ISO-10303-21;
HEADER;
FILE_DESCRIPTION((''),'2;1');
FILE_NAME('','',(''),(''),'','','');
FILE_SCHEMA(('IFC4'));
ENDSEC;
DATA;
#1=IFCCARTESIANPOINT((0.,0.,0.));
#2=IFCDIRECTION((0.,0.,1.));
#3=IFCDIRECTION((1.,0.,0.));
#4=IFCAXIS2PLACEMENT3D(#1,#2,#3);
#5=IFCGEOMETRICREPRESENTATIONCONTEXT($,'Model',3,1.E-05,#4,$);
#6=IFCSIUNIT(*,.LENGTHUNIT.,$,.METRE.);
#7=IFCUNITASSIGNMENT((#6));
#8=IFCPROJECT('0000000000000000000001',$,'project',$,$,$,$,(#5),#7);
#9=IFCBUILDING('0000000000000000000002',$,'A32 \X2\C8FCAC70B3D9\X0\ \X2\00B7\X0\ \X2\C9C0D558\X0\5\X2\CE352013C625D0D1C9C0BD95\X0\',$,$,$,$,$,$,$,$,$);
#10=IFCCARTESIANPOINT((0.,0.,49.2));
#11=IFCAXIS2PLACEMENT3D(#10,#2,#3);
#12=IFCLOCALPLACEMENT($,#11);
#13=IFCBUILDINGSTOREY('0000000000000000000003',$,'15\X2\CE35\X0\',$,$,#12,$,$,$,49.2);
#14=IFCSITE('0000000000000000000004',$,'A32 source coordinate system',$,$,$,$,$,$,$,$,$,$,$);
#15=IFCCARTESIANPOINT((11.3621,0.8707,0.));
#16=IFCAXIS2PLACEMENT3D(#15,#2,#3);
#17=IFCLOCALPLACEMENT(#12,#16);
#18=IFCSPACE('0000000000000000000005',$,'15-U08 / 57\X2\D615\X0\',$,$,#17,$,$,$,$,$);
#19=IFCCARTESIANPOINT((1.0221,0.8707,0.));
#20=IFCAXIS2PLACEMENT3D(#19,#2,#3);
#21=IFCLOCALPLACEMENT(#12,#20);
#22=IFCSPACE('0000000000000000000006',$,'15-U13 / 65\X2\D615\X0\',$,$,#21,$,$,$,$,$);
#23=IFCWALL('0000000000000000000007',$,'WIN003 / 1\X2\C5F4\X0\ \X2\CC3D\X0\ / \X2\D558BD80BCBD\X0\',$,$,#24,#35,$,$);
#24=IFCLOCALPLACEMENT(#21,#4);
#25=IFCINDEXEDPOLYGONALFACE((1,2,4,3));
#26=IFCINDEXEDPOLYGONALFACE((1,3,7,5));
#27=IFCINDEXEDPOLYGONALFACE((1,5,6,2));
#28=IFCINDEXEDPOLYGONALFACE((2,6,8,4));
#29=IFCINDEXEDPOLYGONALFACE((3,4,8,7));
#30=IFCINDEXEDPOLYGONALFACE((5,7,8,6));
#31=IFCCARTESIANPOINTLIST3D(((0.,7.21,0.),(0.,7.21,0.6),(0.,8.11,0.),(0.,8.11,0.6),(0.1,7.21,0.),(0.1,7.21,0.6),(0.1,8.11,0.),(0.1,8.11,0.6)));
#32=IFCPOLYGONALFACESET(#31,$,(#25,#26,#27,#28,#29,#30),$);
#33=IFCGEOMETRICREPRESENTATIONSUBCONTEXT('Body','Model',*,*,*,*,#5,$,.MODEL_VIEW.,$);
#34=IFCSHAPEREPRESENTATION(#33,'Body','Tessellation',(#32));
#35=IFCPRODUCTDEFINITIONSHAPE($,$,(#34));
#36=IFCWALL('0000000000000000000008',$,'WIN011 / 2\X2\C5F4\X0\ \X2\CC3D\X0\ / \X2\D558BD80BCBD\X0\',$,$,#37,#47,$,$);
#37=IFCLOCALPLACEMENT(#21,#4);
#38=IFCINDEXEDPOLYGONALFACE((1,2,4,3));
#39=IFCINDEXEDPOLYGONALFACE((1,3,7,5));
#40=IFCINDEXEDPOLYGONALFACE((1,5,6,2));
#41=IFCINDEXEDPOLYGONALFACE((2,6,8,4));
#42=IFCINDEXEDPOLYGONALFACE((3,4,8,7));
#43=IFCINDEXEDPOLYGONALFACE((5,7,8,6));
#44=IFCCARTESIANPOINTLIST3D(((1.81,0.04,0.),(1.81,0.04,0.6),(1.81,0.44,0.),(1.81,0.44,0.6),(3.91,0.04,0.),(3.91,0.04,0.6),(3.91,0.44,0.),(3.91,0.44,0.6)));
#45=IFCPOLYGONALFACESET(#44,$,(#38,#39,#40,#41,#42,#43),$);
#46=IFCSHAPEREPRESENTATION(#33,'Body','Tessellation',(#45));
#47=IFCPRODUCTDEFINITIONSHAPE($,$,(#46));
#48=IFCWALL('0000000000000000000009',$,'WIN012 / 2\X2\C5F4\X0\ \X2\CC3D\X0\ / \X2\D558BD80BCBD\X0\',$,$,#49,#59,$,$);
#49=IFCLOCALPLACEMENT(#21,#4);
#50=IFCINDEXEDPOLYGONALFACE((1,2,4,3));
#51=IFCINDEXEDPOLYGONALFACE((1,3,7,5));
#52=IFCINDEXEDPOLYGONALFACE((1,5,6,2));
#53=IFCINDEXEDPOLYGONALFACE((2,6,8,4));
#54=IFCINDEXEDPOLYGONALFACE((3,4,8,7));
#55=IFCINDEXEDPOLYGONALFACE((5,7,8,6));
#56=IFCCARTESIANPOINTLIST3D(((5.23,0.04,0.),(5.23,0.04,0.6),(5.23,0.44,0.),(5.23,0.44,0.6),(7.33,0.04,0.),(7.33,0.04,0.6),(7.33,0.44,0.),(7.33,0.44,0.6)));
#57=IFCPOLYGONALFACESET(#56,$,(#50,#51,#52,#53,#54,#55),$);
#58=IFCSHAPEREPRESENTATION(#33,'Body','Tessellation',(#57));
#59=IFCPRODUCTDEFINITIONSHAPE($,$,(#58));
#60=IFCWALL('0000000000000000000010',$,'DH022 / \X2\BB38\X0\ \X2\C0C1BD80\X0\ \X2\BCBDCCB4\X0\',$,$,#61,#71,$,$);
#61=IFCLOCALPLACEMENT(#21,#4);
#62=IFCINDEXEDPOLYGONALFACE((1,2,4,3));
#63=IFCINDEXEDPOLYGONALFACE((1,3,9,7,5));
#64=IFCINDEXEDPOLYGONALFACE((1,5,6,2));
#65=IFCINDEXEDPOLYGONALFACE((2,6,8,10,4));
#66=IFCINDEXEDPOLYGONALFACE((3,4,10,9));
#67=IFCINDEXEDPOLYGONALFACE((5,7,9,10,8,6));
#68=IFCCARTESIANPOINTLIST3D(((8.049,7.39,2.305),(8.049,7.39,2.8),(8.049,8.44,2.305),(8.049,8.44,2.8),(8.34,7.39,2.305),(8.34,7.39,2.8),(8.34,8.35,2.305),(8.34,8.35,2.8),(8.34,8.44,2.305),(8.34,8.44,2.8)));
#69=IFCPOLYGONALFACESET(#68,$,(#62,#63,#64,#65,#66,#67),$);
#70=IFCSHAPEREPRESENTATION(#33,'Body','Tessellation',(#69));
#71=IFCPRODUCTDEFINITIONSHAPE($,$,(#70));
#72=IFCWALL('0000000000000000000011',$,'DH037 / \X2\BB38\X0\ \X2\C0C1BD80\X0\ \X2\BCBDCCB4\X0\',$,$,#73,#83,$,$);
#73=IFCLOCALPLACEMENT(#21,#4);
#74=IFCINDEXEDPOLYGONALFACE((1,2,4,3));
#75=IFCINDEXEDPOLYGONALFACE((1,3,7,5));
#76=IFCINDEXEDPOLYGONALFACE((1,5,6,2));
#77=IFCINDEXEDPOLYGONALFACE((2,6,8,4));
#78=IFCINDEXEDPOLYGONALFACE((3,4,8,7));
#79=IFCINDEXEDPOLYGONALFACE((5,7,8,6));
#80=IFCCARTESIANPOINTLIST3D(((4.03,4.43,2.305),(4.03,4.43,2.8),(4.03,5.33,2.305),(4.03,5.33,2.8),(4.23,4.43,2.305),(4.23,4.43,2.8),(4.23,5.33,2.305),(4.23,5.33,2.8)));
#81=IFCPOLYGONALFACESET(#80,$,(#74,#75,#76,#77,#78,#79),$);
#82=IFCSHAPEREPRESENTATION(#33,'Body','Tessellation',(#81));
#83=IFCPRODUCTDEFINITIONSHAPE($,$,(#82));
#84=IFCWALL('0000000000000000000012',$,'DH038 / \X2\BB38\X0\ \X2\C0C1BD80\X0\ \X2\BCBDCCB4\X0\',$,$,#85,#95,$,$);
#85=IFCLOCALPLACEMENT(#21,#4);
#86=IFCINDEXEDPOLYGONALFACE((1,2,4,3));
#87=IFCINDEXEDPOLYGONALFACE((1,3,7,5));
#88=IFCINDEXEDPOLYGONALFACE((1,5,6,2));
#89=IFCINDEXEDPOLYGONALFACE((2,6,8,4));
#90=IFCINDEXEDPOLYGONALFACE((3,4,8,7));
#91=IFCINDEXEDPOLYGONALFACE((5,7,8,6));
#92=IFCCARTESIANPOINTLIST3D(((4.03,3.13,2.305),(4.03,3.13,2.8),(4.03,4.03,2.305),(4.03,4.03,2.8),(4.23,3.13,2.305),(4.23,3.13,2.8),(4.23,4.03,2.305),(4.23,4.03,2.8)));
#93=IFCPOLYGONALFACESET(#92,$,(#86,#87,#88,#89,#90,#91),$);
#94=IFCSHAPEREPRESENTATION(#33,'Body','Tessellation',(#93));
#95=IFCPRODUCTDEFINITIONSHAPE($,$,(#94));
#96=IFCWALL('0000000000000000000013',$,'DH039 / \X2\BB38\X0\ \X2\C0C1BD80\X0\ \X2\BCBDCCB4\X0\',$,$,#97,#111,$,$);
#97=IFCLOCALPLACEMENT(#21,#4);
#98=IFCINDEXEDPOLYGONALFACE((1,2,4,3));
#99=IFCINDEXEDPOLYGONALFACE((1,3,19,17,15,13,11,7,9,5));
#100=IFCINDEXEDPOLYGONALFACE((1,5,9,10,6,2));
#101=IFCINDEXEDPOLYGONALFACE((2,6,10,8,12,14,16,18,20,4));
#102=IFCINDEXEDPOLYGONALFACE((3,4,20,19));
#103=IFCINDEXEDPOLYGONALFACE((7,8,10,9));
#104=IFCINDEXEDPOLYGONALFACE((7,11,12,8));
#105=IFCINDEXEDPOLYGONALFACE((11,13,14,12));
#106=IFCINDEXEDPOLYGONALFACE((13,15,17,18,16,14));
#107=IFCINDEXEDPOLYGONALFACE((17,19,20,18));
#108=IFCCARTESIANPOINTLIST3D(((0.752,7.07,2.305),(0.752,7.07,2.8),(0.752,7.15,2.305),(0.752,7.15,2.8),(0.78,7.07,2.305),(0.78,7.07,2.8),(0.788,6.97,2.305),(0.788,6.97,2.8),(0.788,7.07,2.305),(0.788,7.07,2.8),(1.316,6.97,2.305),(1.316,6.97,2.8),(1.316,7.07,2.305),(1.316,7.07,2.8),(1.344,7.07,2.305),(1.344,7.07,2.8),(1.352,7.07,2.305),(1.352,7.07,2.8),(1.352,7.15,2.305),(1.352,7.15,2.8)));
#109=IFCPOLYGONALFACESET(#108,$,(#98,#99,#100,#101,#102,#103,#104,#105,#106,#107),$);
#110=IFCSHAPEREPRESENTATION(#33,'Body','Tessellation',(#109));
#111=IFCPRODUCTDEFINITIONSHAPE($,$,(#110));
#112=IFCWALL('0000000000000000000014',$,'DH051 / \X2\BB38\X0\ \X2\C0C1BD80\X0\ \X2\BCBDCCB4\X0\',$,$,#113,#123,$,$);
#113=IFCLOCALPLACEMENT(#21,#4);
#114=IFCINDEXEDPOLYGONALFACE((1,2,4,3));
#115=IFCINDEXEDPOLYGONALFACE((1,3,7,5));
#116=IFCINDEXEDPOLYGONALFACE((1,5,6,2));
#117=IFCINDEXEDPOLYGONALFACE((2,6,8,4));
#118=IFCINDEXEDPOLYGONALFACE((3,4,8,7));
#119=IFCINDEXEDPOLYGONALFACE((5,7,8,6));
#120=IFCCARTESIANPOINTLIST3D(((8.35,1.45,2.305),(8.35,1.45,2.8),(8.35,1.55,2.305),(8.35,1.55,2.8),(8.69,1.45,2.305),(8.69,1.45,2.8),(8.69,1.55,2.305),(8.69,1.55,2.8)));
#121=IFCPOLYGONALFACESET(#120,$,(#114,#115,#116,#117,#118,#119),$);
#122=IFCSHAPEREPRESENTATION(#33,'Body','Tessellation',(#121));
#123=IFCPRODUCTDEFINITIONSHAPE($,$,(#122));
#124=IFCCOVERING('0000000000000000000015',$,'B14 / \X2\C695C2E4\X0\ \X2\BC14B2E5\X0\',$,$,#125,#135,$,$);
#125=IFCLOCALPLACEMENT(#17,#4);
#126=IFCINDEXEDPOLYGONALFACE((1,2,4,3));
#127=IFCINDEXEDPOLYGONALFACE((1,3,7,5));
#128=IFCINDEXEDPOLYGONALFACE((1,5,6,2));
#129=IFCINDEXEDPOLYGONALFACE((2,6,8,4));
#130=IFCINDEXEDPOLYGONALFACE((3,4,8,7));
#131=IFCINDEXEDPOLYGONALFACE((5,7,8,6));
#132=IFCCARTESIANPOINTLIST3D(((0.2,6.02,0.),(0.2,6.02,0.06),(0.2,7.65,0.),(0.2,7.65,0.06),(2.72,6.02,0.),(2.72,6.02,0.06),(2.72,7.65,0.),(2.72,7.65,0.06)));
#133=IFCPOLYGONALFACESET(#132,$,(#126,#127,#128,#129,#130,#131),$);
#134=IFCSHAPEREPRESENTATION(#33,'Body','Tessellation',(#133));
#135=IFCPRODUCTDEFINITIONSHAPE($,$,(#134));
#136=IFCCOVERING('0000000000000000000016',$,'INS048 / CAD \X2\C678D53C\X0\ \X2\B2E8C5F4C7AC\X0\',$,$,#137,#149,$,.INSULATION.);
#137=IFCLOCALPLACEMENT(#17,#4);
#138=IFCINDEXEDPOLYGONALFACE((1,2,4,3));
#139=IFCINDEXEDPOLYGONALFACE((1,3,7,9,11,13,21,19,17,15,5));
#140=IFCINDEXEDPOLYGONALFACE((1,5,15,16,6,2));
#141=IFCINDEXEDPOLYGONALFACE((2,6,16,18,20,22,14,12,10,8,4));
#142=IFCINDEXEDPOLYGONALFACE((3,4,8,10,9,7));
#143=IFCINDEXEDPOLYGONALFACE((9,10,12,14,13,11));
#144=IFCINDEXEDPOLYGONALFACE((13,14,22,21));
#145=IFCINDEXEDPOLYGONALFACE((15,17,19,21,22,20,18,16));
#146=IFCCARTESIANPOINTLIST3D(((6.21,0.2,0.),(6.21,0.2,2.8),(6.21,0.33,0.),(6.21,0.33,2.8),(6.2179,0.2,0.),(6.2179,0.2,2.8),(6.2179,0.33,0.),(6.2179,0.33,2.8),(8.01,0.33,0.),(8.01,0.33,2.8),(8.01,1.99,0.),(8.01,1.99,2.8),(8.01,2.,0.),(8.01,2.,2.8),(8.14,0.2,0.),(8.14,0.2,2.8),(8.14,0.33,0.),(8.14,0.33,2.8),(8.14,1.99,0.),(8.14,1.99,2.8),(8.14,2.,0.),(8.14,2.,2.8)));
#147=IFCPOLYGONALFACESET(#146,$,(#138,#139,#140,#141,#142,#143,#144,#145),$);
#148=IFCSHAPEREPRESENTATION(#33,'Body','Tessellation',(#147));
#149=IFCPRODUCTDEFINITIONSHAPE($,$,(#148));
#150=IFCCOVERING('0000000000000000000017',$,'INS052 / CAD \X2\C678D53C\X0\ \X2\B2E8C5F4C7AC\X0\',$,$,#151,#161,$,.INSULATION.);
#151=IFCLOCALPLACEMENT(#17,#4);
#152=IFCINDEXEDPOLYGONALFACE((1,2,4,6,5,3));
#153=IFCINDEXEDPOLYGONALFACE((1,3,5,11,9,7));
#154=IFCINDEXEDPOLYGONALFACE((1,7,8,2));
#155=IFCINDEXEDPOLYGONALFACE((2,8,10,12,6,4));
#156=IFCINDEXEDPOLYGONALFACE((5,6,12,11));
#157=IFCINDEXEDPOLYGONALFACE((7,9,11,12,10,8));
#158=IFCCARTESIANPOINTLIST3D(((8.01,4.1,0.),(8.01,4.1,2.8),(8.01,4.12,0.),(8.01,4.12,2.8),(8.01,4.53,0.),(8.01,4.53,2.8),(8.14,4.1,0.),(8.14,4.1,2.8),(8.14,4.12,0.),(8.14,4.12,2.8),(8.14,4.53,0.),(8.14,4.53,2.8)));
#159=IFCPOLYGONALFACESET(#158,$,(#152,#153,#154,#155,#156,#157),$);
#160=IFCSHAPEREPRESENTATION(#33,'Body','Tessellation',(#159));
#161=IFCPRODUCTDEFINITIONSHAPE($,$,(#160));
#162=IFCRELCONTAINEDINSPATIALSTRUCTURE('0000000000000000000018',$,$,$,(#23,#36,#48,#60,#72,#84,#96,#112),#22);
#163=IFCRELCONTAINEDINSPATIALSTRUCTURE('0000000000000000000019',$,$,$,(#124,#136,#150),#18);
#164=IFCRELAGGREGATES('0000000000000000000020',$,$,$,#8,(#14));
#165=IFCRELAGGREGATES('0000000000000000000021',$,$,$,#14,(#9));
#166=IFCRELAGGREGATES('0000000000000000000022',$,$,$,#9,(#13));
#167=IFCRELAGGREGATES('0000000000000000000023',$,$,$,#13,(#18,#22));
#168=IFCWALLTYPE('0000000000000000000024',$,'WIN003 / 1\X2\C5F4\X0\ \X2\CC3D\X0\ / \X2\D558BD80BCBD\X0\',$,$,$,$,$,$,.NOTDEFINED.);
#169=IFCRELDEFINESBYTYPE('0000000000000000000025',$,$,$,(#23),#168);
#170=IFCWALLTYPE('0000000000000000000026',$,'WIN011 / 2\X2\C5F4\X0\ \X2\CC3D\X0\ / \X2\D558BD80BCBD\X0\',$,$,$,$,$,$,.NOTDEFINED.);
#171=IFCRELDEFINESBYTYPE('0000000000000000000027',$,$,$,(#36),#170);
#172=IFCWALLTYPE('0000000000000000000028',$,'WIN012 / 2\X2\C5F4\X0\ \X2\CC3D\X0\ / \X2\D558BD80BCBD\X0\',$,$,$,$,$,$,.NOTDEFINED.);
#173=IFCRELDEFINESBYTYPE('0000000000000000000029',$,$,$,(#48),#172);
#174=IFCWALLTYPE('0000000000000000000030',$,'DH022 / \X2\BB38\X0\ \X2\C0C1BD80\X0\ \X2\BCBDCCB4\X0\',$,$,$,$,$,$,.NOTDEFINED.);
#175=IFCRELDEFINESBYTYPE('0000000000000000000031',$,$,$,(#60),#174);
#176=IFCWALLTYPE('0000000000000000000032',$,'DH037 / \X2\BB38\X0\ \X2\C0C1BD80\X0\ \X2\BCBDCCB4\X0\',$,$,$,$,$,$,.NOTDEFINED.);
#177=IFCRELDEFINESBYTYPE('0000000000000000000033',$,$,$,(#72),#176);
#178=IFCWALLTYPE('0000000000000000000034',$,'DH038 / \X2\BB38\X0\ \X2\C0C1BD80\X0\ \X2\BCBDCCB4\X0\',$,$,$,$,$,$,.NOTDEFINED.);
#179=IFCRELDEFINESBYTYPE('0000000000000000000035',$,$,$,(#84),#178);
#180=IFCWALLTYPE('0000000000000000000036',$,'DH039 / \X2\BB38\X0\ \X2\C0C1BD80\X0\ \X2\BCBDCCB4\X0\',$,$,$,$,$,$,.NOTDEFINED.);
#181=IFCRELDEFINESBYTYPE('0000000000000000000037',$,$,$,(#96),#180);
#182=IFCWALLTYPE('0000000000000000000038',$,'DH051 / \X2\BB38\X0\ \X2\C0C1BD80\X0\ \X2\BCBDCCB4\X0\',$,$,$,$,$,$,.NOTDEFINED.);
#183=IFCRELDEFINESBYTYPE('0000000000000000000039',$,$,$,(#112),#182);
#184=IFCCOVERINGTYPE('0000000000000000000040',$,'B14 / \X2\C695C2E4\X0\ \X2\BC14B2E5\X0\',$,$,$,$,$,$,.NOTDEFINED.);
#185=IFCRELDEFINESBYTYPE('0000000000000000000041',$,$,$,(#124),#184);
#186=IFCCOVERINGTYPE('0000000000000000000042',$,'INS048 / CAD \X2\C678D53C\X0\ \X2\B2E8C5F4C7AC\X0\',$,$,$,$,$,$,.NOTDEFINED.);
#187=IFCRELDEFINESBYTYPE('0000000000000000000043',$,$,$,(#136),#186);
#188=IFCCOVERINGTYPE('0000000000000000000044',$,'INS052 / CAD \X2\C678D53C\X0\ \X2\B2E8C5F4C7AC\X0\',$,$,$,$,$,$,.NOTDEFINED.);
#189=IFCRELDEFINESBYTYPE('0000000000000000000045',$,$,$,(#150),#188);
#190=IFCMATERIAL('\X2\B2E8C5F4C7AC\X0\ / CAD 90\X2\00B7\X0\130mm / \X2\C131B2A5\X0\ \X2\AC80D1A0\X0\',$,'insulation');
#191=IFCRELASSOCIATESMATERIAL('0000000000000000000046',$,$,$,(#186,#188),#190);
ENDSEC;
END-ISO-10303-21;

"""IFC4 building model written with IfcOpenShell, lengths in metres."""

from ifc_helpers import new_model, si_unit, frame, origin, origin_with_axes, place, context, subcontext, project, spatial, polyline, outline, extrude, source, transform, mapped, material, type_object, type_shapes, element, save


model = new_model("IFC4")

# Units and contexts
model_context = context("Model", 3, precision=1e-05, world=origin_with_axes())
body_context = subcontext(model_context, "Body", "Model", "MODEL_VIEW")
ifc_project = project(units=[si_unit("LENGTHUNIT", "METRE")], contexts=[model_context])

# Site, building, storey, space
site = spatial("IfcSite", under=ifc_project, Name="A32 source coordinate system")
building = spatial("IfcBuilding", under=site, Name="A32 주거동 · 지하5층–옥탑지붕")
storey_placement = place(None, frame((0.0, 0.0, 49.2), z_axis=(0.0, 0.0, 1.0), x_axis=(1.0, 0.0, 0.0)))
storey = spatial("IfcBuildingStorey", under=building, at=storey_placement, Name="15층", Elevation=49.2)
space_1_placement = place(storey_placement, frame((11.3621, 0.8707, 0.0), z_axis=(0.0, 0.0, 1.0), x_axis=(1.0, 0.0, 0.0)))
space_1 = spatial("IfcSpace", under=storey, at=space_1_placement, Name="15-U08 / 57형")

# Shared definitions
space_2_placement = place(storey_placement, frame((1.0221, 0.8707, 0.0), z_axis=(0.0, 0.0, 1.0), x_axis=(1.0, 0.0, 0.0)))
space_2 = spatial("IfcSpace", under=storey, at=space_2_placement, Name="15-U13 / 65형")

# Walls
wall_type_1 = type_object("IfcWallType", Name="WIN003 / 1열 창 / 하부벽", PredefinedType="NOTDEFINED")
shared_shape_1 = source(origin(), body_context, "Body", "SweptSolid", [
    extrude(outline(polyline([(0.0, 8.11), (0.1, 8.11), (0.1, 7.21), (0.0, 7.21), (0.0, 8.11)])), origin(), (0.0, 0.0, 1.0), 0.6),
])
type_shapes(wall_type_1, [shared_shape_1])
wall_1_placement = place(space_2_placement, origin_with_axes())
element("IfcWall", 1, at=wall_1_placement, inside=space_2, type_object=wall_type_1, Name="WIN003 / 1열 창 / 하부벽", context=body_context, shape_type="MappedRepresentation", body=[
    mapped(shared_shape_1, transform((0.0, 0.0, 0.0), scale=1.0)),
])
wall_type_2 = type_object("IfcWallType", Name="WIN011 / 2열 창 / 하부벽", PredefinedType="NOTDEFINED")
shared_shape_2 = source(origin(), body_context, "Body", "SweptSolid", [
    extrude(outline(polyline([(1.81, 0.44), (3.91, 0.44), (3.91, 0.04), (1.81, 0.04), (1.81, 0.44)])), origin(), (0.0, 0.0, 1.0), 0.6),
])
type_shapes(wall_type_2, [shared_shape_2])
wall_2_placement = place(space_2_placement, origin_with_axes())
element("IfcWall", 2, at=wall_2_placement, inside=space_2, type_object=wall_type_2, Name="WIN011 / 2열 창 / 하부벽", context=body_context, shape_type="MappedRepresentation", body=[
    mapped(shared_shape_2, transform((0.0, 0.0, 0.0), scale=1.0)),
])
wall_type_3 = type_object("IfcWallType", Name="WIN012 / 2열 창 / 하부벽", PredefinedType="NOTDEFINED")
shared_shape_3 = source(origin(), body_context, "Body", "SweptSolid", [
    extrude(outline(polyline([(5.23, 0.44), (7.33, 0.44), (7.33, 0.04), (5.23, 0.04), (5.23, 0.44)])), origin(), (0.0, 0.0, 1.0), 0.6),
])
type_shapes(wall_type_3, [shared_shape_3])
wall_3_placement = place(space_2_placement, origin_with_axes())
element("IfcWall", 3, at=wall_3_placement, inside=space_2, type_object=wall_type_3, Name="WIN012 / 2열 창 / 하부벽", context=body_context, shape_type="MappedRepresentation", body=[
    mapped(shared_shape_3, transform((0.0, 0.0, 0.0), scale=1.0)),
])
wall_type_4 = type_object("IfcWallType", Name="DH022 / 문 상부 벽체", PredefinedType="NOTDEFINED")
shared_shape_4 = source(origin(), body_context, "Body", "SweptSolid", [
    extrude(outline(polyline([(8.049, 7.39), (8.049, 8.44), (8.34, 8.44), (8.34, 8.35), (8.34, 8.35), (8.34, 7.39), (8.049, 7.39)])), frame((0.0, 0.0, 2.305)), (0.0, 0.0, 1.0), 0.495),
])
type_shapes(wall_type_4, [shared_shape_4])
wall_4_placement = place(space_2_placement, origin_with_axes())
element("IfcWall", 4, at=wall_4_placement, inside=space_2, type_object=wall_type_4, Name="DH022 / 문 상부 벽체", context=body_context, shape_type="MappedRepresentation", body=[
    mapped(shared_shape_4, transform((0.0, 0.0, 0.0), scale=1.0)),
])
wall_type_5 = type_object("IfcWallType", Name="DH037 / 문 상부 벽체", PredefinedType="NOTDEFINED")
shared_shape_5 = source(origin(), body_context, "Body", "SweptSolid", [
    extrude(outline(polyline([(4.23, 5.33), (4.23, 4.43), (4.03, 4.43), (4.03, 5.33), (4.23, 5.33)])), frame((0.0, 0.0, 2.305)), (0.0, 0.0, 1.0), 0.495),
])
type_shapes(wall_type_5, [shared_shape_5])
wall_5_placement = place(space_2_placement, origin_with_axes())
element("IfcWall", 5, at=wall_5_placement, inside=space_2, type_object=wall_type_5, Name="DH037 / 문 상부 벽체", context=body_context, shape_type="MappedRepresentation", body=[
    mapped(shared_shape_5, transform((0.0, 0.0, 0.0), scale=1.0)),
])
wall_type_6 = type_object("IfcWallType", Name="DH038 / 문 상부 벽체", PredefinedType="NOTDEFINED")
shared_shape_6 = source(origin(), body_context, "Body", "SweptSolid", [
    extrude(outline(polyline([(4.23, 4.03), (4.23, 3.13), (4.03, 3.13), (4.03, 4.03), (4.23, 4.03)])), frame((0.0, 0.0, 2.305)), (0.0, 0.0, 1.0), 0.495),
])
type_shapes(wall_type_6, [shared_shape_6])
wall_6_placement = place(space_2_placement, origin_with_axes())
element("IfcWall", 6, at=wall_6_placement, inside=space_2, type_object=wall_type_6, Name="DH038 / 문 상부 벽체", context=body_context, shape_type="MappedRepresentation", body=[
    mapped(shared_shape_6, transform((0.0, 0.0, 0.0), scale=1.0)),
])
wall_type_7 = type_object("IfcWallType", Name="DH039 / 문 상부 벽체", PredefinedType="NOTDEFINED")
shared_shape_7 = source(origin(), body_context, "Body", "SweptSolid", [
    extrude(outline(polyline([(1.316, 7.07), (1.316, 6.97), (0.788, 6.97), (0.788, 7.07), (0.78, 7.07), (0.752, 7.07), (0.752, 7.15), (1.352, 7.15), (1.352, 7.07), (1.344, 7.07), (1.316, 7.07)])), frame((0.0, 0.0, 2.305)), (0.0, 0.0, 1.0), 0.495),
])
type_shapes(wall_type_7, [shared_shape_7])
wall_7_placement = place(space_2_placement, origin_with_axes())
element("IfcWall", 7, at=wall_7_placement, inside=space_2, type_object=wall_type_7, Name="DH039 / 문 상부 벽체", context=body_context, shape_type="MappedRepresentation", body=[
    mapped(shared_shape_7, transform((0.0, 0.0, 0.0), scale=1.0)),
])
wall_type_8 = type_object("IfcWallType", Name="DH051 / 문 상부 벽체", PredefinedType="NOTDEFINED")
shared_shape_8 = source(origin(), body_context, "Body", "SweptSolid", [
    extrude(outline(polyline([(8.69, 1.55), (8.69, 1.45), (8.35, 1.45), (8.35, 1.55), (8.69, 1.55)])), frame((0.0, 0.0, 2.305)), (0.0, 0.0, 1.0), 0.495),
])
type_shapes(wall_type_8, [shared_shape_8])
wall_8_placement = place(space_2_placement, origin_with_axes())
element("IfcWall", 8, at=wall_8_placement, inside=space_2, type_object=wall_type_8, Name="DH051 / 문 상부 벽체", context=body_context, shape_type="MappedRepresentation", body=[
    mapped(shared_shape_8, transform((0.0, 0.0, 0.0), scale=1.0)),
])

# Coverings
covering_type_1 = type_object("IfcCoveringType", Name="B14 / 욕실 바닥", PredefinedType="NOTDEFINED")
shared_shape_9 = source(origin(), body_context, "Body", "SweptSolid", [
    extrude(outline(polyline([(0.2, 7.65), (2.72, 7.65), (2.72, 6.02), (0.2, 6.02), (0.2, 7.65)])), origin(), (0.0, 0.0, 1.0), 0.06),
])
type_shapes(covering_type_1, [shared_shape_9])
covering_1_placement = place(space_1_placement, origin_with_axes())
element("IfcCovering", 9, at=covering_1_placement, inside=space_1, type_object=covering_type_1, Name="B14 / 욕실 바닥", context=body_context, shape_type="MappedRepresentation", body=[
    mapped(shared_shape_9, transform((0.0, 0.0, 0.0), scale=1.0)),
])
ifc_material = material(Name="단열재 / CAD 90·130mm / 성능 검토", Category="insulation")
covering_type_2 = type_object("IfcCoveringType", Name="INS048 / CAD 외피 단열재", PredefinedType="NOTDEFINED", material=ifc_material)
shared_shape_10 = source(origin(), body_context, "Body", "SweptSolid", [
    extrude(outline(polyline([(8.01, 1.99), (8.01, 2.0), (8.14, 2.0), (8.14, 1.99), (8.14, 0.33), (8.14, 0.2), (6.2179, 0.2), (6.21, 0.2), (6.21, 0.33), (6.2179, 0.33), (8.01, 0.33), (8.01, 1.99)])), origin(), (0.0, 0.0, 1.0), 2.8),
])
type_shapes(covering_type_2, [shared_shape_10])
covering_2_placement = place(space_1_placement, origin_with_axes())
element("IfcCovering", 10, at=covering_2_placement, inside=space_1, type_object=covering_type_2, Name="INS048 / CAD 외피 단열재", PredefinedType="INSULATION", context=body_context, shape_type="MappedRepresentation", body=[
    mapped(shared_shape_10, transform((0.0, 0.0, 0.0), scale=1.0)),
])
covering_type_3 = type_object("IfcCoveringType", Name="INS052 / CAD 외피 단열재", PredefinedType="NOTDEFINED", material=ifc_material)
shared_shape_11 = source(origin(), body_context, "Body", "SweptSolid", [
    extrude(outline(polyline([(8.14, 4.1), (8.01, 4.1), (8.01, 4.12), (8.01, 4.53), (8.14, 4.53), (8.14, 4.12), (8.14, 4.1)])), origin(), (0.0, 0.0, 1.0), 2.8),
])
type_shapes(covering_type_3, [shared_shape_11])
covering_3_placement = place(space_1_placement, origin_with_axes())
element("IfcCovering", 11, at=covering_3_placement, inside=space_1, type_object=covering_type_3, Name="INS052 / CAD 외피 단열재", PredefinedType="INSULATION", context=body_context, shape_type="MappedRepresentation", body=[
    mapped(shared_shape_11, transform((0.0, 0.0, 0.0), scale=1.0)),
])

save(model, "model.ifc")
